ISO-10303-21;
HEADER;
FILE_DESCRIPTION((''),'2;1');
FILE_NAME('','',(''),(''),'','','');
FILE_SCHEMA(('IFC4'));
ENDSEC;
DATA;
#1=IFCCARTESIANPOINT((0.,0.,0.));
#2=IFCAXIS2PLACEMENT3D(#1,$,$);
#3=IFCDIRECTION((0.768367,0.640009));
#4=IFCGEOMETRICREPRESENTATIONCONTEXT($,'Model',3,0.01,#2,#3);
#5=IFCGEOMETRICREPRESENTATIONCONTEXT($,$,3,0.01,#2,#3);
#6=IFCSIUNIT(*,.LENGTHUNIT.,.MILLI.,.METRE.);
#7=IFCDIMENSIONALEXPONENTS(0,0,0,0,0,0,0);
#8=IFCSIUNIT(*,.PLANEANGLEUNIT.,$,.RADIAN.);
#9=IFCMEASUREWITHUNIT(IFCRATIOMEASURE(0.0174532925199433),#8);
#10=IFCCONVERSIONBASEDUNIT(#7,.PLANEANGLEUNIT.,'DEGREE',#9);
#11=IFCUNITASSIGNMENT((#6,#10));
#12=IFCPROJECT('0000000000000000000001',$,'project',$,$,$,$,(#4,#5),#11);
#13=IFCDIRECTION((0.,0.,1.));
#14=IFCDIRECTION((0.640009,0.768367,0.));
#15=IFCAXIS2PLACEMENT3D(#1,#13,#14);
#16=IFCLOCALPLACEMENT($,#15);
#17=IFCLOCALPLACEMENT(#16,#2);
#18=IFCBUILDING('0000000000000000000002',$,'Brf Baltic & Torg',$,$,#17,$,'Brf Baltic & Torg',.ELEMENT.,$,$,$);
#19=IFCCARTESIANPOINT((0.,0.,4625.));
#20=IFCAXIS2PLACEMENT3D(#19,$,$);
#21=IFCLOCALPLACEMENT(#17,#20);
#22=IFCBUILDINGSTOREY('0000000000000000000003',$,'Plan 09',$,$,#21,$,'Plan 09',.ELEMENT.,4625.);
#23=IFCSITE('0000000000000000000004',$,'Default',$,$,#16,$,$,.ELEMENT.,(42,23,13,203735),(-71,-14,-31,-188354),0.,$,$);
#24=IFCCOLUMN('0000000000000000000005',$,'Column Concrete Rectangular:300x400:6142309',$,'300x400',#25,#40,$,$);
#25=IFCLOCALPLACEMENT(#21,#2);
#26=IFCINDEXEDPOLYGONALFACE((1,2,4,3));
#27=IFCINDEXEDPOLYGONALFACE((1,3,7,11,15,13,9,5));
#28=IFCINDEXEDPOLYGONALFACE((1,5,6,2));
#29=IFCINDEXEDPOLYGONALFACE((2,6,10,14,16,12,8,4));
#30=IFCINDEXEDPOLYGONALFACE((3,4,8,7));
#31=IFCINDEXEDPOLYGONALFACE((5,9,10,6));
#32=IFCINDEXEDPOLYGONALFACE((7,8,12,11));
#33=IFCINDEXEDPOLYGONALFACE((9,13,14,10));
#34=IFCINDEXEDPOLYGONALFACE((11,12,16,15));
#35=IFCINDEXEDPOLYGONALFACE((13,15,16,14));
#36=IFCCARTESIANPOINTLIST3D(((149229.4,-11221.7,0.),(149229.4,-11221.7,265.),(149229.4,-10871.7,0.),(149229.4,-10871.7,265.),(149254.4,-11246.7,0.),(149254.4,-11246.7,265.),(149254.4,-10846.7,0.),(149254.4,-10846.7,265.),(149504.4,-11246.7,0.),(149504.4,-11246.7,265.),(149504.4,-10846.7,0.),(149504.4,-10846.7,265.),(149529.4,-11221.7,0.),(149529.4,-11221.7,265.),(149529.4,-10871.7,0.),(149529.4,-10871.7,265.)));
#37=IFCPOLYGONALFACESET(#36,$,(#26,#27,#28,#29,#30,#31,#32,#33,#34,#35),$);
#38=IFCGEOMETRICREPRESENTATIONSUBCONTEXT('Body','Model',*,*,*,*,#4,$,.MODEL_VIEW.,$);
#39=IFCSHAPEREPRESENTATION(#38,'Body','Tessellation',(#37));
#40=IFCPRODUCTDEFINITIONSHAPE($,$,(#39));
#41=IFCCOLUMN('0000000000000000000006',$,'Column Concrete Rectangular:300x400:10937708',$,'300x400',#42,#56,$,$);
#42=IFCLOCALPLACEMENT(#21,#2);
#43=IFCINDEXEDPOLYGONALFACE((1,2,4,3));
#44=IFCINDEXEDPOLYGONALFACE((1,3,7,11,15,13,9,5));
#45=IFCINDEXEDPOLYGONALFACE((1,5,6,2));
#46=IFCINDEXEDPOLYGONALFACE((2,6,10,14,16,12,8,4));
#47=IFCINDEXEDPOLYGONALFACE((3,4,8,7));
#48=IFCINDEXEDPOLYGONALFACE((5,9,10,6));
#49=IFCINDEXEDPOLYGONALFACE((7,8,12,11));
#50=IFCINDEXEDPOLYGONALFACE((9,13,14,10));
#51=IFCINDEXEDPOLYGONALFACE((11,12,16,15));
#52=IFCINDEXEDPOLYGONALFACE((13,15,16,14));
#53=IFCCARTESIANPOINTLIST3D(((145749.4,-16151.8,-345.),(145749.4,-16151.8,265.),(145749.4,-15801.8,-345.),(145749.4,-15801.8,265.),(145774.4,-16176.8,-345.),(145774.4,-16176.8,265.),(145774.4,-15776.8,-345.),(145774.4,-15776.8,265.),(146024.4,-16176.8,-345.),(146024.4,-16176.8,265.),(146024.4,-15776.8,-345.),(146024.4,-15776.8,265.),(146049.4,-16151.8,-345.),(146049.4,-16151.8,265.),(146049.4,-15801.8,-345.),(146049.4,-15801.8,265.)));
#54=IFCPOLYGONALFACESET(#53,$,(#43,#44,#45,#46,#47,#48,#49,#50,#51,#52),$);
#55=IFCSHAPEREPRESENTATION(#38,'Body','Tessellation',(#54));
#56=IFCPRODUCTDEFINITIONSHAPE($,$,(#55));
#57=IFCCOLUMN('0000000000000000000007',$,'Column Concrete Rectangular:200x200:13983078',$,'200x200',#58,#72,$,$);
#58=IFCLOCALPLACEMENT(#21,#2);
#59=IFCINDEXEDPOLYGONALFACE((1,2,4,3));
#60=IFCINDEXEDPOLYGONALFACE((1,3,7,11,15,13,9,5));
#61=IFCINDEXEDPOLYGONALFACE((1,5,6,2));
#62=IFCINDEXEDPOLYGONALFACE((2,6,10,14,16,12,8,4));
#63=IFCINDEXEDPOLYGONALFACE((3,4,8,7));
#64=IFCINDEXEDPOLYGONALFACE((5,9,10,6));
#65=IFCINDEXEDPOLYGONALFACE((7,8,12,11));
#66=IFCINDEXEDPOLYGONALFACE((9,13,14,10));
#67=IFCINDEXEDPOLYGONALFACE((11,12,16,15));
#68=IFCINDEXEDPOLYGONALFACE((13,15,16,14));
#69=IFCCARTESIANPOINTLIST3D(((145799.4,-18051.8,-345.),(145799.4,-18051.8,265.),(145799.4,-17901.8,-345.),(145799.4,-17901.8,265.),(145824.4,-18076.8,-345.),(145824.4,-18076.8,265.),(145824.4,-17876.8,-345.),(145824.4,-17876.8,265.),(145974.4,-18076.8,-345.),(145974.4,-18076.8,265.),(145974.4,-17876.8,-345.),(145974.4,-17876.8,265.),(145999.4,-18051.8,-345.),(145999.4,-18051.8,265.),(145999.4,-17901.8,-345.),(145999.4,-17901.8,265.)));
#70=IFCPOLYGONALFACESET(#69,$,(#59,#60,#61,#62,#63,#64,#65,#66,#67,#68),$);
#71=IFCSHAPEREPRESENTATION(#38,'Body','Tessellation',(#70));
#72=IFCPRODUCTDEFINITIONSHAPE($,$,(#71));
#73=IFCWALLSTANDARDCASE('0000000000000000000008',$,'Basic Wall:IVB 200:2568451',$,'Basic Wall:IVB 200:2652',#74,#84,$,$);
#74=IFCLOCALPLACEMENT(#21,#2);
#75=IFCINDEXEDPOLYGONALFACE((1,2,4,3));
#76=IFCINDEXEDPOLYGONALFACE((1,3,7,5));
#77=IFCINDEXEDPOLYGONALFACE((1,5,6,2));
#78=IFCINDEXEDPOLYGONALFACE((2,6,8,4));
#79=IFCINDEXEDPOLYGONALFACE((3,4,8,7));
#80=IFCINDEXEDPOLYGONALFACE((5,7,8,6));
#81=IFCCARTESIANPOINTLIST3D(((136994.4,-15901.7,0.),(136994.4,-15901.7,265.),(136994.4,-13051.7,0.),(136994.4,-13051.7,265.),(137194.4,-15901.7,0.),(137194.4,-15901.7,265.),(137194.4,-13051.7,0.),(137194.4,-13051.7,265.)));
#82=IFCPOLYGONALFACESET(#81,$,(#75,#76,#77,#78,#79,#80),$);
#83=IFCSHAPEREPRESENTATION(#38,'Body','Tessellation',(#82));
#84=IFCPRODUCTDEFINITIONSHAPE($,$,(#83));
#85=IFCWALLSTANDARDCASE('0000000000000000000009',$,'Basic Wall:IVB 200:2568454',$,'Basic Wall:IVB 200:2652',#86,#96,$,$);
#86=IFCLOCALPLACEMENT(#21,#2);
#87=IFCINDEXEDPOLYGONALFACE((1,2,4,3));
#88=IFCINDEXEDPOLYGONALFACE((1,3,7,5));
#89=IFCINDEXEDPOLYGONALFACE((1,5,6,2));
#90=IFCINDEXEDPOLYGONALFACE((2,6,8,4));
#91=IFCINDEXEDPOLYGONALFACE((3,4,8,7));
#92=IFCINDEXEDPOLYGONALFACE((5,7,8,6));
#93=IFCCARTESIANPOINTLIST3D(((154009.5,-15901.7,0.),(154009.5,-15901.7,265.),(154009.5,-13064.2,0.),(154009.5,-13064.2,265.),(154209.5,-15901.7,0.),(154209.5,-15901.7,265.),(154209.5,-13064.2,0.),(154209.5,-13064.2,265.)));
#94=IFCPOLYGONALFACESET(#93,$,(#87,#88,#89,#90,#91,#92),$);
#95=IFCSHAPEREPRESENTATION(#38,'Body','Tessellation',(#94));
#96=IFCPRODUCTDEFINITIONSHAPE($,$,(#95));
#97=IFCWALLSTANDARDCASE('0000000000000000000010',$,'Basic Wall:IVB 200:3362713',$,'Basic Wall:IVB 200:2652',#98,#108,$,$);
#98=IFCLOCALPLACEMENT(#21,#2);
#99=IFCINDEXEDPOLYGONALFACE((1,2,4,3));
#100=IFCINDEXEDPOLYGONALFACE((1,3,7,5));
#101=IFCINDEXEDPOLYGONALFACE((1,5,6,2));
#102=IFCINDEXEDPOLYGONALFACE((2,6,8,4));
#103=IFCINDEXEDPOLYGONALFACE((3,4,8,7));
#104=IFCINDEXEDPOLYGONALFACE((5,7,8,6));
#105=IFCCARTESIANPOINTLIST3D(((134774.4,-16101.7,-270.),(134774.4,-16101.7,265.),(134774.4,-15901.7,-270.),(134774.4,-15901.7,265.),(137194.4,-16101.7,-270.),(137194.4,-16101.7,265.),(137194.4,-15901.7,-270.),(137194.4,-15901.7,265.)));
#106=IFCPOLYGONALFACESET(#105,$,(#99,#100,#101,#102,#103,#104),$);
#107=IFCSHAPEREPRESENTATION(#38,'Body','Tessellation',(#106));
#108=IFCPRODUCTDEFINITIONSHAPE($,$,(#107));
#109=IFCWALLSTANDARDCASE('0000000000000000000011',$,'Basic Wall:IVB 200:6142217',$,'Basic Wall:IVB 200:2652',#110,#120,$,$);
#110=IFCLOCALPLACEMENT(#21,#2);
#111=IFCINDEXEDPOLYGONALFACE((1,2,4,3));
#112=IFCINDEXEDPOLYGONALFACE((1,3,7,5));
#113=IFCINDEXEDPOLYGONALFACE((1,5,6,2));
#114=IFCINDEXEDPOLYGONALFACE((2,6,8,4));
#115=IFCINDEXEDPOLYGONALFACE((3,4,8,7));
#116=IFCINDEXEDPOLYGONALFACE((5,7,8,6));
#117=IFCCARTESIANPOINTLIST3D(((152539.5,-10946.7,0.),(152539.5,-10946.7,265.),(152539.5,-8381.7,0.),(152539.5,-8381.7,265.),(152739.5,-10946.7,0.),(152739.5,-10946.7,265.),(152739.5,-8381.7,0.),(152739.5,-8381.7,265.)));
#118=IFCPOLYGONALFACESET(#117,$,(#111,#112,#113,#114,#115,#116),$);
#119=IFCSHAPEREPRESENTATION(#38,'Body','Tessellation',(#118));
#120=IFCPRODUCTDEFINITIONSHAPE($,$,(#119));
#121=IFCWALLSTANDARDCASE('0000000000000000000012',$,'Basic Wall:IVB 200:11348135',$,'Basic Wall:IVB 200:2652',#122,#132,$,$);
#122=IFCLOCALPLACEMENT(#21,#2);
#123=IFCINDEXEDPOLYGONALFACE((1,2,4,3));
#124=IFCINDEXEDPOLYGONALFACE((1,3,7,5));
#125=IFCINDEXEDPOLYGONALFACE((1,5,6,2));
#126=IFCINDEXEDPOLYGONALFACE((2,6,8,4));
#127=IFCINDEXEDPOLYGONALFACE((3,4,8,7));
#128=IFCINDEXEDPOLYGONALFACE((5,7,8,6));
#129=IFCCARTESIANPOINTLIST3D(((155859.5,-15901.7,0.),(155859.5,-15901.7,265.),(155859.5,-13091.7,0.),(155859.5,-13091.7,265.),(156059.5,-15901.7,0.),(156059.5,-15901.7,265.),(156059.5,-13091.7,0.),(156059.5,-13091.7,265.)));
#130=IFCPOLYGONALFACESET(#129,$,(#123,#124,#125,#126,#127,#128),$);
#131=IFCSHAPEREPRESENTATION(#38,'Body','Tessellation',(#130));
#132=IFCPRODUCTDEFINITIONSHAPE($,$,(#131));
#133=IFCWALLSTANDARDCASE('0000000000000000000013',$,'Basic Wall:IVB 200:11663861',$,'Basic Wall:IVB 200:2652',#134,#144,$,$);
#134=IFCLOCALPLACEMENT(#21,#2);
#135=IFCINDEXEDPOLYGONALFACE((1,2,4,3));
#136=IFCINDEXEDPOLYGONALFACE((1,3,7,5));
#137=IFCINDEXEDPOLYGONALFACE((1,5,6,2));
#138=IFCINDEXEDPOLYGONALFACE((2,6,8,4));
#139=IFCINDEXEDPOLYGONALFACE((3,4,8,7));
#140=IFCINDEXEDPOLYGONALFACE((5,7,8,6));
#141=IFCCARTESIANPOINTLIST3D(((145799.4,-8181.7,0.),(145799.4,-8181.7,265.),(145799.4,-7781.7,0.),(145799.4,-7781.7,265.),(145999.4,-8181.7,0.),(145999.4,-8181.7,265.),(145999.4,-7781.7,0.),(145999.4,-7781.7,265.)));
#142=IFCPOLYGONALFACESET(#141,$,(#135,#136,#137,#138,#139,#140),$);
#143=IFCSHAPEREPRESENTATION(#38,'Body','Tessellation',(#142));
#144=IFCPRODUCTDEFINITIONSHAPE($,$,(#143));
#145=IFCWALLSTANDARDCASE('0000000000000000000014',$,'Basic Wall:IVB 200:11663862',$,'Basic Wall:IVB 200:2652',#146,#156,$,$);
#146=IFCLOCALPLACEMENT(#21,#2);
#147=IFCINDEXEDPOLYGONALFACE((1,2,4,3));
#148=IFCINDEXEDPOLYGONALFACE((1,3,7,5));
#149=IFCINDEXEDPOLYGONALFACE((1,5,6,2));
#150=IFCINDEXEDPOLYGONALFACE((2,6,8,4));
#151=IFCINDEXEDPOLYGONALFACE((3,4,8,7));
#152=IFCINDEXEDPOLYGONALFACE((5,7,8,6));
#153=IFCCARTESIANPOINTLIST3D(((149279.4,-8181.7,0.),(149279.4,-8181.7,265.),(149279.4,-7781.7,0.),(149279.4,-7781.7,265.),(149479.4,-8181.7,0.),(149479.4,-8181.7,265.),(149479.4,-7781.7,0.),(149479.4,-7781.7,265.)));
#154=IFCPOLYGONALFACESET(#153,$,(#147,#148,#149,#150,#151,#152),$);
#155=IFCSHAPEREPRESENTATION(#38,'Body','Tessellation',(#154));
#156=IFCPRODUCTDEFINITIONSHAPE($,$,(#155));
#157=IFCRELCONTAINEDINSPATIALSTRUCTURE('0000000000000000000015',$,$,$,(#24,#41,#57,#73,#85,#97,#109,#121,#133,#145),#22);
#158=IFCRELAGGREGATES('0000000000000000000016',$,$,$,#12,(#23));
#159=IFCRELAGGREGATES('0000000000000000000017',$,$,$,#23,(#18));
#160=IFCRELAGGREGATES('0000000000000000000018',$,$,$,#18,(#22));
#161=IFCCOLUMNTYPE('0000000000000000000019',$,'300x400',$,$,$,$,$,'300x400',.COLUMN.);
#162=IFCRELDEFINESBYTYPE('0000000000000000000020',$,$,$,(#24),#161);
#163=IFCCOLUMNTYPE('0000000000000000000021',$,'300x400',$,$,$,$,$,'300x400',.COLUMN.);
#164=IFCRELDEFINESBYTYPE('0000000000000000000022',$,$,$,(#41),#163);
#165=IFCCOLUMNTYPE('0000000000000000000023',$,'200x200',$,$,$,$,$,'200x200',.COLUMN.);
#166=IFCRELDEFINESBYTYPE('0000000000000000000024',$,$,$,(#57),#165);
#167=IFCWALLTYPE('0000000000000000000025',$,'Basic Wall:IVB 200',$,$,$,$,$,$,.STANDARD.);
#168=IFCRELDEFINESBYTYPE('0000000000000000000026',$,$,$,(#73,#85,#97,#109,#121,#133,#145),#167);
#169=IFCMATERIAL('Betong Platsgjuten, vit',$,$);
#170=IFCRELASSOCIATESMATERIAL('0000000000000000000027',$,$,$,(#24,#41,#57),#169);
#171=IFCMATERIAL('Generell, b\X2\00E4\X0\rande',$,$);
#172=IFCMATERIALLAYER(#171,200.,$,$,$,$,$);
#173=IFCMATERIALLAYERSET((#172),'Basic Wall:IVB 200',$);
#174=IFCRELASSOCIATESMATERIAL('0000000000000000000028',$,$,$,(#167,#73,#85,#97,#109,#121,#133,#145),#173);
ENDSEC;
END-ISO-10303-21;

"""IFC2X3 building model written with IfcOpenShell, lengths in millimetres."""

from ifc_helpers import new_model, entity, si_unit, converted_unit, direction, frame, frame_2d, origin, place, context, subcontext, project, spatial, polyline, rectangle, outline, extrude, clip, halfspace, source, transform, mapped, material, layer, layer_set, layer_usage, type_object, type_shapes, element, save


model = new_model("IFC2X3")

# Units and contexts
model_context = context("Model", 3, precision=0.01, world=origin(), true_north=direction((0.768367, 0.640009)))
context_of_model = context(None, 3, precision=0.01, world=origin(), true_north=direction((0.768367, 0.640009)))
body_context = subcontext(model_context, "Body", "Model", "MODEL_VIEW")
ifc_project = project(units=[si_unit("LENGTHUNIT", "METRE", prefix="MILLI"), converted_unit("PLANEANGLEUNIT", "DEGREE", entity("IfcRatioMeasure", 0.0174532925199433), si_unit("PLANEANGLEUNIT", "RADIAN"), dimensions=[0, 0, 0, 0, 0, 0, 0])], contexts=[model_context, context_of_model])

# Site, building, storey
site_placement = place(None, frame((0.0, 0.0, 0.0), z_axis=(0.0, 0.0, 1.0), x_axis=(0.640009, 0.768367, 0.0)))
site = spatial("IfcSite", under=ifc_project, at=site_placement, Name="Default", CompositionType="ELEMENT", RefLatitude=(42, 23, 13, 203735), RefLongitude=(-71, -14, -31, -188354), RefElevation=0.0)
building_placement = place(site_placement, origin())
building = spatial("IfcBuilding", under=site, at=building_placement, Name="Brf Baltic & Torg", LongName="Brf Baltic & Torg", CompositionType="ELEMENT")
storey_placement = place(building_placement, frame((0.0, 0.0, 4625.0)))
storey = spatial("IfcBuildingStorey", under=building, at=storey_placement, Name="Plan 09", LongName="Plan 09", CompositionType="ELEMENT", Elevation=4625.0)

# Columns
ifc_material_1 = material(Name="Betong Platsgjuten, vit")
column_type_1 = type_object("IfcColumnType", Name="300x400", ElementType="300x400", PredefinedType="COLUMN")
shared_shape_1 = source(origin(), body_context, "Body", "SweptSolid", [
    extrude(outline(polyline([(-175.0, -150.0), (175.0, -150.0), (200.0, -125.0), (200.0, 125.0), (175.0, 150.0), (-175.0, 150.0), (-200.0, 125.0), (-200.0, -125.0), (-175.0, -150.0)])), frame((0.0, 0.0, 4625.0), z_axis=(0.0, 0.0, 1.0), x_axis=(0.0, -1.0, 0.0)), (0.0, 0.0, 1.0), 265.0),
])
type_shapes(column_type_1, [shared_shape_1])
column_1_placement = place(storey_placement, frame((149379.4, -11046.7, -4625.0)))
element("IfcColumn", 1, at=column_1_placement, inside=storey, type_object=column_type_1, material=ifc_material_1, Name="Column Concrete Rectangular:300x400:6142309", ObjectType="300x400", context=body_context, shape_type="MappedRepresentation", body=[
    mapped(shared_shape_1, transform((0.0, 0.0, 0.0), scale=1.0)),
])
column_type_2 = type_object("IfcColumnType", Name="300x400", ElementType="300x400", PredefinedType="COLUMN")
shared_shape_2 = source(origin(), body_context, "Body", "SweptSolid", [
    extrude(outline(polyline([(-175.0, -150.0), (175.0, -150.0), (200.0, -125.0), (200.0, 125.0), (175.0, 150.0), (-175.0, 150.0), (-200.0, 125.0), (-200.0, -125.0), (-175.0, -150.0)])), frame((0.0, 0.0, 4280.0), z_axis=(0.0, 0.0, 1.0), x_axis=(0.0, -1.0, 0.0)), (0.0, 0.0, 1.0), 610.0),
])
type_shapes(column_type_2, [shared_shape_2])
column_2_placement = place(storey_placement, frame((145899.4, -15976.8, -4625.0)))
element("IfcColumn", 2, at=column_2_placement, inside=storey, type_object=column_type_2, material=ifc_material_1, Name="Column Concrete Rectangular:300x400:10937708", ObjectType="300x400", context=body_context, shape_type="MappedRepresentation", body=[
    mapped(shared_shape_2, transform((0.0, 0.0, 0.0), scale=1.0)),
])
column_type_3 = type_object("IfcColumnType", Name="200x200", ElementType="200x200", PredefinedType="COLUMN")
shared_shape_3 = source(origin(), body_context, "Body", "SweptSolid", [
    extrude(outline(polyline([(-75.0, -100.0), (75.0, -100.0), (100.0, -75.0), (100.0, 75.0), (75.0, 100.0), (-75.0, 100.0), (-100.0, 75.0), (-100.0, -75.0), (-75.0, -100.0)])), frame((0.0, 0.0, 4280.0), z_axis=(0.0, 0.0, 1.0), x_axis=(0.0, -1.0, 0.0)), (0.0, 0.0, 1.0), 610.0),
])
type_shapes(column_type_3, [shared_shape_3])
column_3_placement = place(storey_placement, frame((145899.4, -17976.8, -4625.0)))
element("IfcColumn", 3, at=column_3_placement, inside=storey, type_object=column_type_3, material=ifc_material_1, Name="Column Concrete Rectangular:200x200:13983078", ObjectType="200x200", context=body_context, shape_type="MappedRepresentation", body=[
    mapped(shared_shape_3, transform((0.0, 0.0, 0.0), scale=1.0)),
])

# Shared definitions
ifc_material_2 = material(Name="Generell, bärande")

# Walls
ifc_layer_1 = layer(ifc_material_2, 200.0)
ifc_layer_set_1 = layer_set([ifc_layer_1], Name="Basic Wall:IVB 200")
ifc_layer_usage_1 = layer_usage(ifc_layer_set_1, "AXIS2", "NEGATIVE", 100.0)
wall_type = type_object("IfcWallType", Name="Basic Wall:IVB 200", PredefinedType="STANDARD", material=ifc_layer_set_1)
wall_1_placement = place(storey_placement, frame((137094.4, -15901.7, 0.0), z_axis=(0.0, 0.0, 1.0), x_axis=(0.0, 1.0, 0.0)))
element("IfcWallStandardCase", 4, at=wall_1_placement, inside=storey, type_object=wall_type, material=ifc_layer_usage_1, Name="Basic Wall:IVB 200:2568451", ObjectType="Basic Wall:IVB 200:2652", context=body_context, shape_type="Clipping", body=[
    clip(extrude(rectangle(XDim=2850.0, YDim=200.0, at=frame_2d((1425.0, 0.0), x_axis=(-1.0, 0.0))), origin(), (0.0, 0.0, 1.0), 265.0), halfspace(origin(), True)),
])
ifc_layer_usage_2 = layer_usage(ifc_layer_set_1, "AXIS2", "NEGATIVE", 100.0)
wall_2_placement = place(storey_placement, frame((154109.5, -15901.7, 0.0), z_axis=(0.0, 0.0, 1.0), x_axis=(0.0, 1.0, 0.0)))
element("IfcWallStandardCase", 5, at=wall_2_placement, inside=storey, type_object=wall_type, material=ifc_layer_usage_2, Name="Basic Wall:IVB 200:2568454", ObjectType="Basic Wall:IVB 200:2652", context=body_context, shape_type="Clipping", body=[
    clip(extrude(rectangle(XDim=2837.5, YDim=200.0, at=frame_2d((1418.7, 0.0), x_axis=(-1.0, 0.0))), origin(), (0.0, 0.0, 1.0), 265.0), halfspace(origin(), True)),
])

# Walls
ifc_layer_usage_3 = layer_usage(ifc_layer_set_1, "AXIS2", "NEGATIVE", 100.0)
wall_3_placement = place(storey_placement, frame((137194.4, -16001.7, -270.0), z_axis=(0.0, 0.0, 1.0), x_axis=(-1.0, 0.0, 0.0)))
element("IfcWallStandardCase", 6, at=wall_3_placement, inside=storey, type_object=wall_type, material=ifc_layer_usage_3, Name="Basic Wall:IVB 200:3362713", ObjectType="Basic Wall:IVB 200:2652", context=body_context, shape_type="Clipping", body=[
    clip(extrude(rectangle(XDim=2420.0, YDim=200.0, at=frame_2d((1210.0, 0.0), x_axis=(-1.0, 0.0))), origin(), (0.0, 0.0, 1.0), 535.0), halfspace(frame((0.0, 0.0, -270.0)), True)),
])
ifc_layer_usage_4 = layer_usage(ifc_layer_set_1, "AXIS2", "NEGATIVE", 100.0)
wall_4_placement = place(storey_placement, frame((152639.5, -10946.7, 0.0), z_axis=(0.0, 0.0, 1.0), x_axis=(0.0, 1.0, 0.0)))
element("IfcWallStandardCase", 7, at=wall_4_placement, inside=storey, type_object=wall_type, material=ifc_layer_usage_4, Name="Basic Wall:IVB 200:6142217", ObjectType="Basic Wall:IVB 200:2652", context=body_context, shape_type="Clipping", body=[
    clip(extrude(rectangle(XDim=2565.0, YDim=200.0, at=frame_2d((1282.5, 0.0), x_axis=(-1.0, 0.0))), origin(), (0.0, 0.0, 1.0), 265.0), halfspace(origin(), True)),
])
ifc_layer_usage_5 = layer_usage(ifc_layer_set_1, "AXIS2", "NEGATIVE", 100.0)
wall_5_placement = place(storey_placement, frame((155959.5, -15901.7, 0.0), z_axis=(0.0, 0.0, 1.0), x_axis=(0.0, 1.0, 0.0)))
element("IfcWallStandardCase", 8, at=wall_5_placement, inside=storey, type_object=wall_type, material=ifc_layer_usage_5, Name="Basic Wall:IVB 200:11348135", ObjectType="Basic Wall:IVB 200:2652", context=body_context, shape_type="Clipping", body=[
    clip(extrude(rectangle(XDim=2810.0, YDim=200.0, at=frame_2d((1405.0, 0.0), x_axis=(-1.0, 0.0))), origin(), (0.0, 0.0, 1.0), 265.0), halfspace(origin(), True)),
])
ifc_layer_usage_6 = layer_usage(ifc_layer_set_1, "AXIS2", "POSITIVE", -100.0)
wall_6_placement = place(storey_placement, frame((145899.4, -7781.7, 0.0), z_axis=(0.0, 0.0, 1.0), x_axis=(0.0, -1.0, 0.0)))
element("IfcWallStandardCase", 9, at=wall_6_placement, inside=storey, type_object=wall_type, material=ifc_layer_usage_6, Name="Basic Wall:IVB 200:11663861", ObjectType="Basic Wall:IVB 200:2652", context=body_context, shape_type="Clipping", body=[
    clip(extrude(rectangle(XDim=400.0, YDim=200.0, at=frame_2d((200.0, 0.0), x_axis=(-1.0, 0.0))), origin(), (0.0, 0.0, 1.0), 265.0), halfspace(origin(), True)),
])
ifc_layer_usage_7 = layer_usage(ifc_layer_set_1, "AXIS2", "NEGATIVE", 100.0)
wall_7_placement = place(storey_placement, frame((149379.4, -8181.7, 0.0), z_axis=(0.0, 0.0, 1.0), x_axis=(0.0, 1.0, 0.0)))
element("IfcWallStandardCase", 10, at=wall_7_placement, inside=storey, type_object=wall_type, material=ifc_layer_usage_7, Name="Basic Wall:IVB 200:11663862", ObjectType="Basic Wall:IVB 200:2652", context=body_context, shape_type="Clipping", body=[
    clip(extrude(rectangle(XDim=400.0, YDim=200.0, at=frame_2d((200.0, 0.0), x_axis=(-1.0, 0.0))), origin(), (0.0, 0.0, 1.0), 265.0), halfspace(origin(), True)),
])

save(model, "model.ifc")
